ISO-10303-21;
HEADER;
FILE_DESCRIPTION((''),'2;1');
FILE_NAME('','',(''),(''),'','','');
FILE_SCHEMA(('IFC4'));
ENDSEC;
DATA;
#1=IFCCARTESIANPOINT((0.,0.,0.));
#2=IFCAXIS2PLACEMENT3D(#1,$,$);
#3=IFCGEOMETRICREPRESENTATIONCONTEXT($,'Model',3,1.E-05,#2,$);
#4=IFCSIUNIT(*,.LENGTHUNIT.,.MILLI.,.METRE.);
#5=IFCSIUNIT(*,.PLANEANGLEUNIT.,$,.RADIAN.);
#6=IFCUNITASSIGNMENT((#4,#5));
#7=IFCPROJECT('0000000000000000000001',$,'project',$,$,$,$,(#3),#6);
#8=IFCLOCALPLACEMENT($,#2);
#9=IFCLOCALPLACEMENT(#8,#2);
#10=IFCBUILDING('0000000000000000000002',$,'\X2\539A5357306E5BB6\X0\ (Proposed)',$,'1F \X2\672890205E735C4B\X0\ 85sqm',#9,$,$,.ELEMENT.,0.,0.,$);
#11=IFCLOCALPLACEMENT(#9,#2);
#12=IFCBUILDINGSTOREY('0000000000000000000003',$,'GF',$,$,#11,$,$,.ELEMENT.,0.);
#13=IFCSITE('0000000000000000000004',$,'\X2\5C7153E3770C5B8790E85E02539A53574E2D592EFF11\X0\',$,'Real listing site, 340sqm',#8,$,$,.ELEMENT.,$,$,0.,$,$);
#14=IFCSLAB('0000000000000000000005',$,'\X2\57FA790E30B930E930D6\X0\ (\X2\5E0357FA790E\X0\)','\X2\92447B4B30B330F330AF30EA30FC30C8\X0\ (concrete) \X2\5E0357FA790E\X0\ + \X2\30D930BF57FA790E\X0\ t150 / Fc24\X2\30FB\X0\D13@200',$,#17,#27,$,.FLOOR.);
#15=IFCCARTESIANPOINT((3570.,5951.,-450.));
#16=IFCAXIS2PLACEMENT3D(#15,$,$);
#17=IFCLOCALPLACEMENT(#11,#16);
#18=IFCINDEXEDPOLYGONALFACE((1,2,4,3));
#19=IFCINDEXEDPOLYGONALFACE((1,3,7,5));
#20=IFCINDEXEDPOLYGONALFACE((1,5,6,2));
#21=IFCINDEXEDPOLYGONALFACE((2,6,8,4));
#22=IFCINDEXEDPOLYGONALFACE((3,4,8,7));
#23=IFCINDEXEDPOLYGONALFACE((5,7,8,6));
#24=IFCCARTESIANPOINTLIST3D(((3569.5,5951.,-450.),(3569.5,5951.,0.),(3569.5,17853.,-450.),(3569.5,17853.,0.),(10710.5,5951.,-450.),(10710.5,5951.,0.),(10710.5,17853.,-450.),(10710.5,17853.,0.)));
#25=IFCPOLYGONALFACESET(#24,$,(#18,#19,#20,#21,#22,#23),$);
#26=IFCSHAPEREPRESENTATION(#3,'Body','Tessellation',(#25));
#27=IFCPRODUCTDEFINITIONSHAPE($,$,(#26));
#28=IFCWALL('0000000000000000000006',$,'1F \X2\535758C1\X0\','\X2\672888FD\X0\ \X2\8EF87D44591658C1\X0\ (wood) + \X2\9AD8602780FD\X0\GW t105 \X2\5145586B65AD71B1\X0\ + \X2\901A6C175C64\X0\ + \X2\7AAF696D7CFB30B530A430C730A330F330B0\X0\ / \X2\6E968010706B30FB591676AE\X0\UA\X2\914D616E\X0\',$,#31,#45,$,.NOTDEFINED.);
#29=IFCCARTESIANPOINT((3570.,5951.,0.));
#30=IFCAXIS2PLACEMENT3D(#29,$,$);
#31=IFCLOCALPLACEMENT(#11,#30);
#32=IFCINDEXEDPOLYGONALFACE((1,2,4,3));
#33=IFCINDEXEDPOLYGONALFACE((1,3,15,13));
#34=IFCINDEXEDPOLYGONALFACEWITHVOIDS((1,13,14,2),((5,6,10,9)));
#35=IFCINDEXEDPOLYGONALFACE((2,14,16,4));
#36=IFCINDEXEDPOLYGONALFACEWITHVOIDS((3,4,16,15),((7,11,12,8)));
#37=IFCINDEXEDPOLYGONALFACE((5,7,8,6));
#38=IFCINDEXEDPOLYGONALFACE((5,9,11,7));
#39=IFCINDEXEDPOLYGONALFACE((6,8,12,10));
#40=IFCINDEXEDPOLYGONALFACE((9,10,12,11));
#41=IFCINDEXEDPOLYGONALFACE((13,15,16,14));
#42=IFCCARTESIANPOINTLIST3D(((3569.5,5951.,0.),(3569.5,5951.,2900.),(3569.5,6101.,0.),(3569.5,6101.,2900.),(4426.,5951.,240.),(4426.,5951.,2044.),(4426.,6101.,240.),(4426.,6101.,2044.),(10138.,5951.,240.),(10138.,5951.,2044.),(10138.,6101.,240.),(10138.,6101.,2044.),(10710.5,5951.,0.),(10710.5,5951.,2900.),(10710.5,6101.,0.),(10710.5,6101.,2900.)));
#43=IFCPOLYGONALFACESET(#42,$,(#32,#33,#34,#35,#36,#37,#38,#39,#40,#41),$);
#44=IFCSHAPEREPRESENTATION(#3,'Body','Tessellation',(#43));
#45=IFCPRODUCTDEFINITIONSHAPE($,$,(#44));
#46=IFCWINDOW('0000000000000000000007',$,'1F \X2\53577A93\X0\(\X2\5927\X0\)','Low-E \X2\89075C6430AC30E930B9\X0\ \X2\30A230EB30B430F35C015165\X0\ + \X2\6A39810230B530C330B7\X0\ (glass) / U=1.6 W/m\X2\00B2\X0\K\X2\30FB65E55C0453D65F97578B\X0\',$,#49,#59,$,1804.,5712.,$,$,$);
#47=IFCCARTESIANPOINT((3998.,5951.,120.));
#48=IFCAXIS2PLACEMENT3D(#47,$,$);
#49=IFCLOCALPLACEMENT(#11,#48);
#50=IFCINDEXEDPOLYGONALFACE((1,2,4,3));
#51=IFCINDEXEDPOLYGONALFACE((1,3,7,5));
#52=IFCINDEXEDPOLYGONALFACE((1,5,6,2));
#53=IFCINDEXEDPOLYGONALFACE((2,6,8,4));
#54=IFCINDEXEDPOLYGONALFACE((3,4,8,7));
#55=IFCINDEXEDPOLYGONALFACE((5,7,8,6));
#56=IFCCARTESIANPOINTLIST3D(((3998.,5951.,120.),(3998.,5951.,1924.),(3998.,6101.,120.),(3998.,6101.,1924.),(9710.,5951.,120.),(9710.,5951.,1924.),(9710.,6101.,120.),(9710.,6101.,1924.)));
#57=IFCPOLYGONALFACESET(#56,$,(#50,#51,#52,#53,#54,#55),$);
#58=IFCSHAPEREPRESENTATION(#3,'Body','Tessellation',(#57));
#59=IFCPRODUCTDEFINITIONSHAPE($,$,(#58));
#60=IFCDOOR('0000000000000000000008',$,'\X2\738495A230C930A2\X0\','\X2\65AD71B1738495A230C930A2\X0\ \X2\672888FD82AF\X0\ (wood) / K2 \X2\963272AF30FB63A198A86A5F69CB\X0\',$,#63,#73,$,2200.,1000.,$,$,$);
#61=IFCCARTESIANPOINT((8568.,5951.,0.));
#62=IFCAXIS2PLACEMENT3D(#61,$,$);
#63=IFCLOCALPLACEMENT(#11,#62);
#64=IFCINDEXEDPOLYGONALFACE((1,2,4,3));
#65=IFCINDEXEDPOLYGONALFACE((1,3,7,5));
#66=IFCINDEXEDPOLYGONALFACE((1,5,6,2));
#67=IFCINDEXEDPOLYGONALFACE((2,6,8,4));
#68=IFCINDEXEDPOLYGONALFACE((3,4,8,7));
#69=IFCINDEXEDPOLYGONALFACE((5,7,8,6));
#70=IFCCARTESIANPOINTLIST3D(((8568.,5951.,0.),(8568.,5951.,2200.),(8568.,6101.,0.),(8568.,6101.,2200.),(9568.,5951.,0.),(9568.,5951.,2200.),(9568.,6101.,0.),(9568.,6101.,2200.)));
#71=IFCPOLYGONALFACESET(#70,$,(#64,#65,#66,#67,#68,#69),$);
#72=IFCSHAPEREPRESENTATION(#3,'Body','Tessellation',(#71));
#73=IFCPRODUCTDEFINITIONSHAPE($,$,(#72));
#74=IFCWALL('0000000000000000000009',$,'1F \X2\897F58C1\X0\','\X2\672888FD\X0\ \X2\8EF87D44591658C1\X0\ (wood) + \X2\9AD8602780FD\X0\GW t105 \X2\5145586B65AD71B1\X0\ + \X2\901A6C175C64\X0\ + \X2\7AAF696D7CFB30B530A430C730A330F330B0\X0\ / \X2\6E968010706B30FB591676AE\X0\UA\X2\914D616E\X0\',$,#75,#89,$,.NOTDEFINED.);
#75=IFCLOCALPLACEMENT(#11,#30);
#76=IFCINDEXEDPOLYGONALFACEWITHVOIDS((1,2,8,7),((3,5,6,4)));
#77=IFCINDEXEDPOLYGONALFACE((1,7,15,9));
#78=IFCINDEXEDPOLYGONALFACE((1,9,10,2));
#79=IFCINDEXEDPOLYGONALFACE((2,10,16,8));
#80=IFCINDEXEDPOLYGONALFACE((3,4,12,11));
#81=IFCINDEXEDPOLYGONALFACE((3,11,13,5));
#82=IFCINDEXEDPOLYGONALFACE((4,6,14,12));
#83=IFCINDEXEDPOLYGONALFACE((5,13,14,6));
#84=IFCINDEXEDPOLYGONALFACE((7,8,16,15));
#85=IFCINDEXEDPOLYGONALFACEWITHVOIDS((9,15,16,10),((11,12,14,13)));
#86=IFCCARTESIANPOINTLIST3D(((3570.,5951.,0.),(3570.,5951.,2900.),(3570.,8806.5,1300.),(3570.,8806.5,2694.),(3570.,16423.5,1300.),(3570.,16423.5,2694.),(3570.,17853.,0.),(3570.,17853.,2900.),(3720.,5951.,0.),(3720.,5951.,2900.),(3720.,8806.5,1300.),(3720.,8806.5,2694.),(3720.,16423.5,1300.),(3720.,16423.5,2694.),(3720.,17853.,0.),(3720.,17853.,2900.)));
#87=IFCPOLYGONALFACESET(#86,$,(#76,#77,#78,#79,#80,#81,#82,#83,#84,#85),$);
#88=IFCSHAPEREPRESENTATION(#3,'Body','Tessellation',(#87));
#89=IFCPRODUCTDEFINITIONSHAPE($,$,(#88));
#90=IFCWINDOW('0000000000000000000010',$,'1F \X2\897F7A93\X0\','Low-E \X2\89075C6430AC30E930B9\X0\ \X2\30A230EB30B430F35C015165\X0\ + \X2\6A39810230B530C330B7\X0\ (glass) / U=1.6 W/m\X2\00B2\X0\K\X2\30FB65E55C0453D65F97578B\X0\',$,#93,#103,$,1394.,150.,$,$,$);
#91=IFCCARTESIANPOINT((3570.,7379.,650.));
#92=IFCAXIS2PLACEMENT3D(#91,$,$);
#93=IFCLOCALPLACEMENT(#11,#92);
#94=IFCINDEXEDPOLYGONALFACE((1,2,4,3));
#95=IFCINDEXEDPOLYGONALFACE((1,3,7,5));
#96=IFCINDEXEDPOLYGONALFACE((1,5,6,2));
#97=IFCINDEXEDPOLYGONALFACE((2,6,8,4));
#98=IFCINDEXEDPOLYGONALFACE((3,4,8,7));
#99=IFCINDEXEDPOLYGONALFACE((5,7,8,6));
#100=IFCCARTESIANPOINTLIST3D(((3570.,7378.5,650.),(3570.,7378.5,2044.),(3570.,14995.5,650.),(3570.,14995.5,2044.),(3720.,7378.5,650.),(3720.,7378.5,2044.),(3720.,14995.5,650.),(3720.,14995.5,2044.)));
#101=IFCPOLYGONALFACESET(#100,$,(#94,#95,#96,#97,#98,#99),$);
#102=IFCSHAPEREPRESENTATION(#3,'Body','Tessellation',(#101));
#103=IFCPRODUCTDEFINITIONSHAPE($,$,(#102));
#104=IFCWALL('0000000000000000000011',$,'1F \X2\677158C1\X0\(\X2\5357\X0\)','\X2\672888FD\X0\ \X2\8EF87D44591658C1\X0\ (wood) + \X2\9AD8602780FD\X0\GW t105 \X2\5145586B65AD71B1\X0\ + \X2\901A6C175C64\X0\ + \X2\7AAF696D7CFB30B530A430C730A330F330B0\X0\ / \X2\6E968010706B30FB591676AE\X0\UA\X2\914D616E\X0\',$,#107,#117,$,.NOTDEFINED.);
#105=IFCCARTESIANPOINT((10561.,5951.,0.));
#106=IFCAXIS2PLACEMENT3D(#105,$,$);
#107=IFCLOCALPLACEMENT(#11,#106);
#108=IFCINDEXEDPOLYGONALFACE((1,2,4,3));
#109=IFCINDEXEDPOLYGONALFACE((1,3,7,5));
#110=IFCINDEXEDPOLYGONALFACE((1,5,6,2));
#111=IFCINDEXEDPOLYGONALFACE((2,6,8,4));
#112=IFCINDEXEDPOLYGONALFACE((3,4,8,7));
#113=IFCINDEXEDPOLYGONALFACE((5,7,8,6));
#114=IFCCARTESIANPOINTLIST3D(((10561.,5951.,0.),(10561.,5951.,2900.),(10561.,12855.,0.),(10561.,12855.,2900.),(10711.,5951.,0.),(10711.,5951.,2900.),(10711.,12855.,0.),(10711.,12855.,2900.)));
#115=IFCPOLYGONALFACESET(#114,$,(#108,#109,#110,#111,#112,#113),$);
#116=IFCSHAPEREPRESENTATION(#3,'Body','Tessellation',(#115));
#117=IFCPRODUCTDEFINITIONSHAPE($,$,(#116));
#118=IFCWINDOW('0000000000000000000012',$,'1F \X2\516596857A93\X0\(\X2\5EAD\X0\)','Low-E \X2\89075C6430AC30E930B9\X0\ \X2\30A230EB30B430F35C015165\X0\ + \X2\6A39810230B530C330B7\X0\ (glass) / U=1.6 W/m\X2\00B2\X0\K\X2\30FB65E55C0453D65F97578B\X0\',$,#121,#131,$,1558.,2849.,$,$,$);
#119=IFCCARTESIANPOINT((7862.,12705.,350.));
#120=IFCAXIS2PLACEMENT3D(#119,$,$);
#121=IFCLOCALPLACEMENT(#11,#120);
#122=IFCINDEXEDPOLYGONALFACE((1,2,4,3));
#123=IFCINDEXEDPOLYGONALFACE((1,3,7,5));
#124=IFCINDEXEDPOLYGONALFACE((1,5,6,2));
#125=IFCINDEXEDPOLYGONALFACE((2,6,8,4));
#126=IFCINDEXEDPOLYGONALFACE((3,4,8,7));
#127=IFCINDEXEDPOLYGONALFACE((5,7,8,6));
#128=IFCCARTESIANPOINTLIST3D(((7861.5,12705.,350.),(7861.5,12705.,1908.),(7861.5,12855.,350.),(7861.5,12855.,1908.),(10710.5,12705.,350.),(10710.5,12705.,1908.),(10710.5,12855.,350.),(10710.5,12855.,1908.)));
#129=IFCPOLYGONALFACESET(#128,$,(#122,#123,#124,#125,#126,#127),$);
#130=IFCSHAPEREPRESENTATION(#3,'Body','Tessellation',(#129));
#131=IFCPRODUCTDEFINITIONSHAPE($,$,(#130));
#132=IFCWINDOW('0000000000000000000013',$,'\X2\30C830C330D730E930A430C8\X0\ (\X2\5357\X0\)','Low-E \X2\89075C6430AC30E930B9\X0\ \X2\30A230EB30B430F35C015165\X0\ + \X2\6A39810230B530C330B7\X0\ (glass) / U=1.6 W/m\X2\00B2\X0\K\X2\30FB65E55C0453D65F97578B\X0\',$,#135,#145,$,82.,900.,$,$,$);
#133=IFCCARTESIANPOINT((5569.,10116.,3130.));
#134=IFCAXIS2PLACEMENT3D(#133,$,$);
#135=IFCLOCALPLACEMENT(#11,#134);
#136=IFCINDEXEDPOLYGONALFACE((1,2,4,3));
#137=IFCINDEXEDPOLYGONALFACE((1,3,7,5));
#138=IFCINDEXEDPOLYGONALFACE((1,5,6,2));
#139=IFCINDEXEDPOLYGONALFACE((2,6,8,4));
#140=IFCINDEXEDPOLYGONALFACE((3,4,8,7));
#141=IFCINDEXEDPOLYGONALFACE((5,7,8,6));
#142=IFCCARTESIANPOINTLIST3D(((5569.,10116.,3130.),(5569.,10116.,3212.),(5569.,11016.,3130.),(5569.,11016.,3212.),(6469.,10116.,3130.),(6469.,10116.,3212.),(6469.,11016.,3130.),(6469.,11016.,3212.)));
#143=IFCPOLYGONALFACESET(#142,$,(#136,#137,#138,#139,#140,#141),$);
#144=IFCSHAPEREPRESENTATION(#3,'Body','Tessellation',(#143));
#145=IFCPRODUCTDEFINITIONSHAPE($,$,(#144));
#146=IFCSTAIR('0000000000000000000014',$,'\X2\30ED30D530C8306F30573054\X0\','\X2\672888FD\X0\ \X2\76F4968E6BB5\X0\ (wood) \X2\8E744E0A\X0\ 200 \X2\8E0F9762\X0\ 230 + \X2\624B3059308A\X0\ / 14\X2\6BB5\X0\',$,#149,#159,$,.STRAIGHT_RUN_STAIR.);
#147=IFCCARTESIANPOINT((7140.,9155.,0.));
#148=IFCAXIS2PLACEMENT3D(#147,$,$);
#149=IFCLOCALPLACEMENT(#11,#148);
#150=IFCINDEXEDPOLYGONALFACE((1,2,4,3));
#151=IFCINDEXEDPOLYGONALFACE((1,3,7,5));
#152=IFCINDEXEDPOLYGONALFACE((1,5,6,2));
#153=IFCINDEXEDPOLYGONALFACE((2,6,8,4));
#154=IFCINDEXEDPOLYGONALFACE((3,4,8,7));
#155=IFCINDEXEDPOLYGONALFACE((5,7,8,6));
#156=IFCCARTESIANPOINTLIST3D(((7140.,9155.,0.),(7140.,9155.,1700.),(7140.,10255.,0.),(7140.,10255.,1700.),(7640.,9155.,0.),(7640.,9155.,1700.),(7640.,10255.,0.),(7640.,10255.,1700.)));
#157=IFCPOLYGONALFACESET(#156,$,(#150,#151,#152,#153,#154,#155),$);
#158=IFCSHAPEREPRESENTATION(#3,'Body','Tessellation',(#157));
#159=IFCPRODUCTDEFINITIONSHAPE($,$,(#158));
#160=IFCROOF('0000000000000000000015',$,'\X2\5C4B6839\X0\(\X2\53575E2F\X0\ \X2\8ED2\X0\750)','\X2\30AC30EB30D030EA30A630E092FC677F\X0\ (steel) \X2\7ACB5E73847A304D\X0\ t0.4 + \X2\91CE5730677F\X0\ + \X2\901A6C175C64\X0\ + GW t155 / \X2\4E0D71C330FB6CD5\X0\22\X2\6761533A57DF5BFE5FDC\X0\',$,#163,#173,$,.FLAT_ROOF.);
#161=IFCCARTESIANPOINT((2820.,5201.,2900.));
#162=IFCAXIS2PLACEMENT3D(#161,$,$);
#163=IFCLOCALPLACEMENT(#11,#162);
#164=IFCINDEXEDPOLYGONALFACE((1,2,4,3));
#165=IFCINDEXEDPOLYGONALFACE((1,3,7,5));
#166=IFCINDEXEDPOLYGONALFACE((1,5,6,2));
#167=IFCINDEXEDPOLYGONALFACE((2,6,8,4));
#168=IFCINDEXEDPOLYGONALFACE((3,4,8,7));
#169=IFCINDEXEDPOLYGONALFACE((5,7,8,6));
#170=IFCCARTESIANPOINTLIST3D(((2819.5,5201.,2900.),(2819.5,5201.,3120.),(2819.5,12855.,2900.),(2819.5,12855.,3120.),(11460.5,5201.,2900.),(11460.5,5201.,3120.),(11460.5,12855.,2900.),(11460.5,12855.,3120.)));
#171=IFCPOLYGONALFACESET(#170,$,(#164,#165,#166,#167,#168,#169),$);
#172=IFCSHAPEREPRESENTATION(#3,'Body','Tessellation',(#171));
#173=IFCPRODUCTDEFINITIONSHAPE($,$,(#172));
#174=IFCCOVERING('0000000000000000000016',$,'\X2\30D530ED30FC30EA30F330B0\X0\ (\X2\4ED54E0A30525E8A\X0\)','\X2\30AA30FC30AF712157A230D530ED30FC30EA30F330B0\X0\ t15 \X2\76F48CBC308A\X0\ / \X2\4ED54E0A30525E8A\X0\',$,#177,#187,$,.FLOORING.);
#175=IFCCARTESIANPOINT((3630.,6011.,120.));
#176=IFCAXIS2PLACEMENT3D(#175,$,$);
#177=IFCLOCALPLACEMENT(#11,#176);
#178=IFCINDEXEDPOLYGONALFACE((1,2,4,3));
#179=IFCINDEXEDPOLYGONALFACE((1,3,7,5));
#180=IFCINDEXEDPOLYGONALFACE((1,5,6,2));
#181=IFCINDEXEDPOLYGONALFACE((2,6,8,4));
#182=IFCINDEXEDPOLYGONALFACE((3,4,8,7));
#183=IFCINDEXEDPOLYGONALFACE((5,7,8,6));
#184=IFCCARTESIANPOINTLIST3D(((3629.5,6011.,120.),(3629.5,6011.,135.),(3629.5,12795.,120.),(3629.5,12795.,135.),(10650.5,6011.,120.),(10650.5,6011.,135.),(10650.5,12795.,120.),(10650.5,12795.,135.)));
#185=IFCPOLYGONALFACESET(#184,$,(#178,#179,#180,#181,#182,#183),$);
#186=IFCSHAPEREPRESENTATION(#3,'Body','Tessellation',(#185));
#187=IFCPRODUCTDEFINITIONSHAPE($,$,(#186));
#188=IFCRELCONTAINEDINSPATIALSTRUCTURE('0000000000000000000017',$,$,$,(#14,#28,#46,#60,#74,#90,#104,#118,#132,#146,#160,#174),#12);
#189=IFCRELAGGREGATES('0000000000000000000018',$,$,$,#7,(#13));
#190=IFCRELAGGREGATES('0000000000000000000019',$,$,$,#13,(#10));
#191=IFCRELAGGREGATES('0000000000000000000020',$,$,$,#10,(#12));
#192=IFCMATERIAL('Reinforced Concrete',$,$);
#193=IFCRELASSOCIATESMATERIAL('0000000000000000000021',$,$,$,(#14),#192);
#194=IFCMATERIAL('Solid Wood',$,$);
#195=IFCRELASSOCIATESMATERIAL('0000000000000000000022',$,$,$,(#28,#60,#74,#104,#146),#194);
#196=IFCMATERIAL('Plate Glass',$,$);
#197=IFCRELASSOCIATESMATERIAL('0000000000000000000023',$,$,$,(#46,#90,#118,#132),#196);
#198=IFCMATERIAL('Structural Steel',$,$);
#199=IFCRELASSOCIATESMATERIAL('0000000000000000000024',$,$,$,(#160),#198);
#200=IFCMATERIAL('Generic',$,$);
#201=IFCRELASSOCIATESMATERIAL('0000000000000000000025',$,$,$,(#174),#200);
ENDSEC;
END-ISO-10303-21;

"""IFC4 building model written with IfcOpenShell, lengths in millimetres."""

from ifc_helpers import new_model, si_unit, frame, frame_2d, origin, place, context, project, spatial, rectangle, extrude, material, element, fill, save


model = new_model("IFC4")

# Units and contexts
model_context = context("Model", 3, precision=1e-05, world=origin())
ifc_project = project(units=[si_unit("LENGTHUNIT", "METRE", prefix="MILLI"), si_unit("PLANEANGLEUNIT", "RADIAN")], contexts=[model_context])

# Site, building, storey
site_placement = place(None, origin())
site = spatial("IfcSite", under=ifc_project, at=site_placement, Name="山口県宇部市厚南中央１", ObjectType="Real listing site, 340sqm", CompositionType="ELEMENT", RefElevation=0.0)
building_placement = place(site_placement, origin())
building = spatial("IfcBuilding", under=site, at=building_placement, Name="厚南の家 (Proposed)", ObjectType="1F 木造平屋 85sqm", CompositionType="ELEMENT", ElevationOfRefHeight=0.0, ElevationOfTerrain=0.0)
storey_placement = place(building_placement, origin())
storey = spatial("IfcBuildingStorey", under=building, at=storey_placement, Name="GF", CompositionType="ELEMENT", Elevation=0.0)

# Slab
ifc_material_1 = material(Name="Reinforced Concrete")
slab_1_placement = place(storey_placement, frame((3570.0, 5951.0, -450.0)))
element("IfcSlab", 1, at=slab_1_placement, inside=storey, material=ifc_material_1, Name="基礎スラブ (布基礎)", Description="鉄筋コンクリート (concrete) 布基礎 + ベタ基礎 t150 / Fc24・D13@200", PredefinedType="FLOOR", context=model_context, shape_type="SweptSolid", body=[
    extrude(rectangle(XDim=7141.0, YDim=11902.0, at=frame_2d((3570.0, 5951.0))), frame((3570.0, 5951.0, -450.0)), (0.0, 0.0, 1.0), 450.0),
])
ifc_material_2 = material(Name="Solid Wood")

# Wall, openings, window, door
wall_1_placement = place(storey_placement, frame((3570.0, 5951.0, 0.0)))
wall_1 = element("IfcWall", 2, at=wall_1_placement, inside=storey, material=ifc_material_2, Name="1F 南壁", Description="木製 軸組外壁 (wood) + 高性能GW t105 充填断熱 + 通気層 + 窯業系サイディング / 準耐火・外皮UA配慮", PredefinedType="NOTDEFINED", context=model_context, shape_type="SweptSolid", body=[
    extrude(rectangle(XDim=7141.0, YDim=150.0, at=frame_2d((3570.0, 75.0))), frame((3570.0, 5951.0, 0.0)), (0.0, 0.0, 1.0), 2900.0),
])
opening_1_placement = place(storey_placement, frame((3998.0, 5951.0, 120.0)))
opening_1 = element("IfcOpeningElement", 3, at=opening_1_placement, cuts=wall_1, PredefinedType="NOTDEFINED", context=model_context, shape_type="SweptSolid", body=[
    extrude(rectangle(XDim=5712.0, YDim=150.0, at=frame_2d((2856.0, 75.0))), frame((3998.0, 5951.0, 120.0)), (0.0, 0.0, 1.0), 1804.0),
])
opening_2_placement = place(storey_placement, frame((8568.0, 5951.0, 0.0)))
opening_2 = element("IfcOpeningElement", 4, at=opening_2_placement, cuts=wall_1, PredefinedType="NOTDEFINED", context=model_context, shape_type="SweptSolid", body=[
    extrude(rectangle(XDim=1000.0, YDim=150.0, at=frame_2d((500.0, 75.0))), frame((8568.0, 5951.0, 0.0)), (0.0, 0.0, 1.0), 2200.0),
])
ifc_material_3 = material(Name="Plate Glass")
window_1_placement = place(storey_placement, frame((3998.0, 5951.0, 120.0)))
window_1 = element("IfcWindow", 5, at=window_1_placement, inside=storey, material=ifc_material_3, Name="1F 南窓(大)", Description="Low-E 複層ガラス アルゴン封入 + 樹脂サッシ (glass) / U=1.6 W/m²K・日射取得型", OverallHeight=1804.0, OverallWidth=5712.0, context=model_context, shape_type="SweptSolid", body=[
    extrude(rectangle(XDim=5712.0, YDim=150.0, at=frame_2d((2856.0, 75.0))), frame((3998.0, 5951.0, 120.0)), (0.0, 0.0, 1.0), 1804.0),
])
fill(opening_1, window_1)
door_1_placement = place(storey_placement, frame((8568.0, 5951.0, 0.0)))
door_1 = element("IfcDoor", 6, at=door_1_placement, inside=storey, material=ifc_material_2, Name="玄関ドア", Description="断熱玄関ドア 木製芯 (wood) / K2 防犯・採風機構", OverallHeight=2200.0, OverallWidth=1000.0, context=model_context, shape_type="SweptSolid", body=[
    extrude(rectangle(XDim=1000.0, YDim=150.0, at=frame_2d((500.0, 75.0))), frame((8568.0, 5951.0, 0.0)), (0.0, 0.0, 1.0), 2200.0),
])
fill(opening_2, door_1)

# Walls, openings, windows
wall_2_placement = place(storey_placement, frame((3570.0, 5951.0, 0.0)))
wall_2 = element("IfcWall", 7, at=wall_2_placement, inside=storey, material=ifc_material_2, Name="1F 西壁", Description="木製 軸組外壁 (wood) + 高性能GW t105 充填断熱 + 通気層 + 窯業系サイディング / 準耐火・外皮UA配慮", PredefinedType="NOTDEFINED", context=model_context, shape_type="SweptSolid", body=[
    extrude(rectangle(XDim=150.0, YDim=11902.0, at=frame_2d((75.0, 5951.0))), frame((3570.0, 5951.0, 0.0)), (0.0, 0.0, 1.0), 2900.0),
])
opening_3_placement = place(storey_placement, frame((3570.0, 7379.0, 650.0)))
opening_3 = element("IfcOpeningElement", 8, at=opening_3_placement, cuts=wall_2, PredefinedType="NOTDEFINED", context=model_context, shape_type="SweptSolid", body=[
    extrude(rectangle(XDim=150.0, YDim=7617.0, at=frame_2d((75.0, 3808.0))), frame((3570.0, 7379.0, 650.0)), (0.0, 0.0, 1.0), 1394.0),
])
window_2_placement = place(storey_placement, frame((3570.0, 7379.0, 650.0)))
window_2 = element("IfcWindow", 9, at=window_2_placement, inside=storey, material=ifc_material_3, Name="1F 西窓", Description="Low-E 複層ガラス アルゴン封入 + 樹脂サッシ (glass) / U=1.6 W/m²K・日射取得型", OverallHeight=1394.0, OverallWidth=150.0, context=model_context, shape_type="SweptSolid", body=[
    extrude(rectangle(XDim=150.0, YDim=7617.0, at=frame_2d((75.0, 3808.0))), frame((3570.0, 7379.0, 650.0)), (0.0, 0.0, 1.0), 1394.0),
])
fill(opening_3, window_2)
wall_3_placement = place(storey_placement, frame((10561.0, 5951.0, 0.0)))
wall_3 = element("IfcWall", 10, at=wall_3_placement, inside=storey, material=ifc_material_2, Name="1F 東壁(南)", Description="木製 軸組外壁 (wood) + 高性能GW t105 充填断熱 + 通気層 + 窯業系サイディング / 準耐火・外皮UA配慮", PredefinedType="NOTDEFINED", context=model_context, shape_type="SweptSolid", body=[
    extrude(rectangle(XDim=150.0, YDim=6904.0, at=frame_2d((75.0, 3452.0))), frame((10561.0, 5951.0, 0.0)), (0.0, 0.0, 1.0), 2900.0),
])
opening_4_placement = place(storey_placement, frame((7862.0, 12705.0, 350.0)))
opening_4 = element("IfcOpeningElement", 11, at=opening_4_placement, cuts=wall_3, PredefinedType="NOTDEFINED", context=model_context, shape_type="SweptSolid", body=[
    extrude(rectangle(XDim=2849.0, YDim=150.0, at=frame_2d((1424.0, 75.0))), frame((7862.0, 12705.0, 350.0)), (0.0, 0.0, 1.0), 1558.0),
])
window_3_placement = place(storey_placement, frame((7862.0, 12705.0, 350.0)))
window_3 = element("IfcWindow", 12, at=window_3_placement, inside=storey, material=ifc_material_3, Name="1F 入隅窓(庭)", Description="Low-E 複層ガラス アルゴン封入 + 樹脂サッシ (glass) / U=1.6 W/m²K・日射取得型", OverallHeight=1558.0, OverallWidth=2849.0, context=model_context, shape_type="SweptSolid", body=[
    extrude(rectangle(XDim=2849.0, YDim=150.0, at=frame_2d((1424.0, 75.0))), frame((7862.0, 12705.0, 350.0)), (0.0, 0.0, 1.0), 1558.0),
])
fill(opening_4, window_3)

# Window
window_4_placement = place(storey_placement, frame((5569.0, 10116.0, 3130.0)))
element("IfcWindow", 13, at=window_4_placement, inside=storey, material=ifc_material_3, Name="トップライト (南)", Description="Low-E 複層ガラス アルゴン封入 + 樹脂サッシ (glass) / U=1.6 W/m²K・日射取得型", OverallHeight=82.0, OverallWidth=900.0, context=model_context, shape_type="SweptSolid", body=[
    extrude(rectangle(XDim=900.0, YDim=900.0, at=frame_2d((450.0, 450.0))), frame((5569.0, 10116.0, 3130.0)), (0.0, 0.0, 1.0), 82.0),
])

# Stair
stair_placement = place(storey_placement, frame((7140.0, 9155.0, 0.0)))
element("IfcStair", 14, at=stair_placement, inside=storey, material=ifc_material_2, Name="ロフトはしご", Description="木製 直階段 (wood) 蹴上 200 踏面 230 + 手すり / 14段", PredefinedType="STRAIGHT_RUN_STAIR", context=model_context, shape_type="SweptSolid", body=[
    extrude(rectangle(XDim=500.0, YDim=1100.0, at=frame_2d((250.0, 550.0))), frame((7140.0, 9155.0, 0.0)), (0.0, 0.0, 1.0), 1700.0),
])

# Roof
ifc_material_4 = material(Name="Structural Steel")
roof_placement = place(storey_placement, frame((2820.0, 5201.0, 2900.0)))
element("IfcRoof", 15, at=roof_placement, inside=storey, material=ifc_material_4, Name="屋根(南帯 軒750)", Description="ガルバリウム鋼板 (steel) 立平葺き t0.4 + 野地板 + 通気層 + GW t155 / 不燃・法22条区域対応", PredefinedType="FLAT_ROOF", context=model_context, shape_type="SweptSolid", body=[
    extrude(rectangle(XDim=8641.0, YDim=7654.0, at=frame_2d((4320.0, 3827.0))), frame((2820.0, 5201.0, 2900.0)), (0.0, 0.0, 1.0), 220.0),
])

# Covering
ifc_material_5 = material(Name="Generic")
covering_placement = place(storey_placement, frame((3630.0, 6011.0, 120.0)))
element("IfcCovering", 16, at=covering_placement, inside=storey, material=ifc_material_5, Name="フローリング (仕上げ床)", Description="オーク無垢フローリング t15 直貼り / 仕上げ床", PredefinedType="FLOORING", context=model_context, shape_type="SweptSolid", body=[
    extrude(rectangle(XDim=7021.0, YDim=6784.0, at=frame_2d((3510.0, 3392.0))), frame((3630.0, 6011.0, 120.0)), (0.0, 0.0, 1.0), 15.0),
])

save(model, "model.ifc")
